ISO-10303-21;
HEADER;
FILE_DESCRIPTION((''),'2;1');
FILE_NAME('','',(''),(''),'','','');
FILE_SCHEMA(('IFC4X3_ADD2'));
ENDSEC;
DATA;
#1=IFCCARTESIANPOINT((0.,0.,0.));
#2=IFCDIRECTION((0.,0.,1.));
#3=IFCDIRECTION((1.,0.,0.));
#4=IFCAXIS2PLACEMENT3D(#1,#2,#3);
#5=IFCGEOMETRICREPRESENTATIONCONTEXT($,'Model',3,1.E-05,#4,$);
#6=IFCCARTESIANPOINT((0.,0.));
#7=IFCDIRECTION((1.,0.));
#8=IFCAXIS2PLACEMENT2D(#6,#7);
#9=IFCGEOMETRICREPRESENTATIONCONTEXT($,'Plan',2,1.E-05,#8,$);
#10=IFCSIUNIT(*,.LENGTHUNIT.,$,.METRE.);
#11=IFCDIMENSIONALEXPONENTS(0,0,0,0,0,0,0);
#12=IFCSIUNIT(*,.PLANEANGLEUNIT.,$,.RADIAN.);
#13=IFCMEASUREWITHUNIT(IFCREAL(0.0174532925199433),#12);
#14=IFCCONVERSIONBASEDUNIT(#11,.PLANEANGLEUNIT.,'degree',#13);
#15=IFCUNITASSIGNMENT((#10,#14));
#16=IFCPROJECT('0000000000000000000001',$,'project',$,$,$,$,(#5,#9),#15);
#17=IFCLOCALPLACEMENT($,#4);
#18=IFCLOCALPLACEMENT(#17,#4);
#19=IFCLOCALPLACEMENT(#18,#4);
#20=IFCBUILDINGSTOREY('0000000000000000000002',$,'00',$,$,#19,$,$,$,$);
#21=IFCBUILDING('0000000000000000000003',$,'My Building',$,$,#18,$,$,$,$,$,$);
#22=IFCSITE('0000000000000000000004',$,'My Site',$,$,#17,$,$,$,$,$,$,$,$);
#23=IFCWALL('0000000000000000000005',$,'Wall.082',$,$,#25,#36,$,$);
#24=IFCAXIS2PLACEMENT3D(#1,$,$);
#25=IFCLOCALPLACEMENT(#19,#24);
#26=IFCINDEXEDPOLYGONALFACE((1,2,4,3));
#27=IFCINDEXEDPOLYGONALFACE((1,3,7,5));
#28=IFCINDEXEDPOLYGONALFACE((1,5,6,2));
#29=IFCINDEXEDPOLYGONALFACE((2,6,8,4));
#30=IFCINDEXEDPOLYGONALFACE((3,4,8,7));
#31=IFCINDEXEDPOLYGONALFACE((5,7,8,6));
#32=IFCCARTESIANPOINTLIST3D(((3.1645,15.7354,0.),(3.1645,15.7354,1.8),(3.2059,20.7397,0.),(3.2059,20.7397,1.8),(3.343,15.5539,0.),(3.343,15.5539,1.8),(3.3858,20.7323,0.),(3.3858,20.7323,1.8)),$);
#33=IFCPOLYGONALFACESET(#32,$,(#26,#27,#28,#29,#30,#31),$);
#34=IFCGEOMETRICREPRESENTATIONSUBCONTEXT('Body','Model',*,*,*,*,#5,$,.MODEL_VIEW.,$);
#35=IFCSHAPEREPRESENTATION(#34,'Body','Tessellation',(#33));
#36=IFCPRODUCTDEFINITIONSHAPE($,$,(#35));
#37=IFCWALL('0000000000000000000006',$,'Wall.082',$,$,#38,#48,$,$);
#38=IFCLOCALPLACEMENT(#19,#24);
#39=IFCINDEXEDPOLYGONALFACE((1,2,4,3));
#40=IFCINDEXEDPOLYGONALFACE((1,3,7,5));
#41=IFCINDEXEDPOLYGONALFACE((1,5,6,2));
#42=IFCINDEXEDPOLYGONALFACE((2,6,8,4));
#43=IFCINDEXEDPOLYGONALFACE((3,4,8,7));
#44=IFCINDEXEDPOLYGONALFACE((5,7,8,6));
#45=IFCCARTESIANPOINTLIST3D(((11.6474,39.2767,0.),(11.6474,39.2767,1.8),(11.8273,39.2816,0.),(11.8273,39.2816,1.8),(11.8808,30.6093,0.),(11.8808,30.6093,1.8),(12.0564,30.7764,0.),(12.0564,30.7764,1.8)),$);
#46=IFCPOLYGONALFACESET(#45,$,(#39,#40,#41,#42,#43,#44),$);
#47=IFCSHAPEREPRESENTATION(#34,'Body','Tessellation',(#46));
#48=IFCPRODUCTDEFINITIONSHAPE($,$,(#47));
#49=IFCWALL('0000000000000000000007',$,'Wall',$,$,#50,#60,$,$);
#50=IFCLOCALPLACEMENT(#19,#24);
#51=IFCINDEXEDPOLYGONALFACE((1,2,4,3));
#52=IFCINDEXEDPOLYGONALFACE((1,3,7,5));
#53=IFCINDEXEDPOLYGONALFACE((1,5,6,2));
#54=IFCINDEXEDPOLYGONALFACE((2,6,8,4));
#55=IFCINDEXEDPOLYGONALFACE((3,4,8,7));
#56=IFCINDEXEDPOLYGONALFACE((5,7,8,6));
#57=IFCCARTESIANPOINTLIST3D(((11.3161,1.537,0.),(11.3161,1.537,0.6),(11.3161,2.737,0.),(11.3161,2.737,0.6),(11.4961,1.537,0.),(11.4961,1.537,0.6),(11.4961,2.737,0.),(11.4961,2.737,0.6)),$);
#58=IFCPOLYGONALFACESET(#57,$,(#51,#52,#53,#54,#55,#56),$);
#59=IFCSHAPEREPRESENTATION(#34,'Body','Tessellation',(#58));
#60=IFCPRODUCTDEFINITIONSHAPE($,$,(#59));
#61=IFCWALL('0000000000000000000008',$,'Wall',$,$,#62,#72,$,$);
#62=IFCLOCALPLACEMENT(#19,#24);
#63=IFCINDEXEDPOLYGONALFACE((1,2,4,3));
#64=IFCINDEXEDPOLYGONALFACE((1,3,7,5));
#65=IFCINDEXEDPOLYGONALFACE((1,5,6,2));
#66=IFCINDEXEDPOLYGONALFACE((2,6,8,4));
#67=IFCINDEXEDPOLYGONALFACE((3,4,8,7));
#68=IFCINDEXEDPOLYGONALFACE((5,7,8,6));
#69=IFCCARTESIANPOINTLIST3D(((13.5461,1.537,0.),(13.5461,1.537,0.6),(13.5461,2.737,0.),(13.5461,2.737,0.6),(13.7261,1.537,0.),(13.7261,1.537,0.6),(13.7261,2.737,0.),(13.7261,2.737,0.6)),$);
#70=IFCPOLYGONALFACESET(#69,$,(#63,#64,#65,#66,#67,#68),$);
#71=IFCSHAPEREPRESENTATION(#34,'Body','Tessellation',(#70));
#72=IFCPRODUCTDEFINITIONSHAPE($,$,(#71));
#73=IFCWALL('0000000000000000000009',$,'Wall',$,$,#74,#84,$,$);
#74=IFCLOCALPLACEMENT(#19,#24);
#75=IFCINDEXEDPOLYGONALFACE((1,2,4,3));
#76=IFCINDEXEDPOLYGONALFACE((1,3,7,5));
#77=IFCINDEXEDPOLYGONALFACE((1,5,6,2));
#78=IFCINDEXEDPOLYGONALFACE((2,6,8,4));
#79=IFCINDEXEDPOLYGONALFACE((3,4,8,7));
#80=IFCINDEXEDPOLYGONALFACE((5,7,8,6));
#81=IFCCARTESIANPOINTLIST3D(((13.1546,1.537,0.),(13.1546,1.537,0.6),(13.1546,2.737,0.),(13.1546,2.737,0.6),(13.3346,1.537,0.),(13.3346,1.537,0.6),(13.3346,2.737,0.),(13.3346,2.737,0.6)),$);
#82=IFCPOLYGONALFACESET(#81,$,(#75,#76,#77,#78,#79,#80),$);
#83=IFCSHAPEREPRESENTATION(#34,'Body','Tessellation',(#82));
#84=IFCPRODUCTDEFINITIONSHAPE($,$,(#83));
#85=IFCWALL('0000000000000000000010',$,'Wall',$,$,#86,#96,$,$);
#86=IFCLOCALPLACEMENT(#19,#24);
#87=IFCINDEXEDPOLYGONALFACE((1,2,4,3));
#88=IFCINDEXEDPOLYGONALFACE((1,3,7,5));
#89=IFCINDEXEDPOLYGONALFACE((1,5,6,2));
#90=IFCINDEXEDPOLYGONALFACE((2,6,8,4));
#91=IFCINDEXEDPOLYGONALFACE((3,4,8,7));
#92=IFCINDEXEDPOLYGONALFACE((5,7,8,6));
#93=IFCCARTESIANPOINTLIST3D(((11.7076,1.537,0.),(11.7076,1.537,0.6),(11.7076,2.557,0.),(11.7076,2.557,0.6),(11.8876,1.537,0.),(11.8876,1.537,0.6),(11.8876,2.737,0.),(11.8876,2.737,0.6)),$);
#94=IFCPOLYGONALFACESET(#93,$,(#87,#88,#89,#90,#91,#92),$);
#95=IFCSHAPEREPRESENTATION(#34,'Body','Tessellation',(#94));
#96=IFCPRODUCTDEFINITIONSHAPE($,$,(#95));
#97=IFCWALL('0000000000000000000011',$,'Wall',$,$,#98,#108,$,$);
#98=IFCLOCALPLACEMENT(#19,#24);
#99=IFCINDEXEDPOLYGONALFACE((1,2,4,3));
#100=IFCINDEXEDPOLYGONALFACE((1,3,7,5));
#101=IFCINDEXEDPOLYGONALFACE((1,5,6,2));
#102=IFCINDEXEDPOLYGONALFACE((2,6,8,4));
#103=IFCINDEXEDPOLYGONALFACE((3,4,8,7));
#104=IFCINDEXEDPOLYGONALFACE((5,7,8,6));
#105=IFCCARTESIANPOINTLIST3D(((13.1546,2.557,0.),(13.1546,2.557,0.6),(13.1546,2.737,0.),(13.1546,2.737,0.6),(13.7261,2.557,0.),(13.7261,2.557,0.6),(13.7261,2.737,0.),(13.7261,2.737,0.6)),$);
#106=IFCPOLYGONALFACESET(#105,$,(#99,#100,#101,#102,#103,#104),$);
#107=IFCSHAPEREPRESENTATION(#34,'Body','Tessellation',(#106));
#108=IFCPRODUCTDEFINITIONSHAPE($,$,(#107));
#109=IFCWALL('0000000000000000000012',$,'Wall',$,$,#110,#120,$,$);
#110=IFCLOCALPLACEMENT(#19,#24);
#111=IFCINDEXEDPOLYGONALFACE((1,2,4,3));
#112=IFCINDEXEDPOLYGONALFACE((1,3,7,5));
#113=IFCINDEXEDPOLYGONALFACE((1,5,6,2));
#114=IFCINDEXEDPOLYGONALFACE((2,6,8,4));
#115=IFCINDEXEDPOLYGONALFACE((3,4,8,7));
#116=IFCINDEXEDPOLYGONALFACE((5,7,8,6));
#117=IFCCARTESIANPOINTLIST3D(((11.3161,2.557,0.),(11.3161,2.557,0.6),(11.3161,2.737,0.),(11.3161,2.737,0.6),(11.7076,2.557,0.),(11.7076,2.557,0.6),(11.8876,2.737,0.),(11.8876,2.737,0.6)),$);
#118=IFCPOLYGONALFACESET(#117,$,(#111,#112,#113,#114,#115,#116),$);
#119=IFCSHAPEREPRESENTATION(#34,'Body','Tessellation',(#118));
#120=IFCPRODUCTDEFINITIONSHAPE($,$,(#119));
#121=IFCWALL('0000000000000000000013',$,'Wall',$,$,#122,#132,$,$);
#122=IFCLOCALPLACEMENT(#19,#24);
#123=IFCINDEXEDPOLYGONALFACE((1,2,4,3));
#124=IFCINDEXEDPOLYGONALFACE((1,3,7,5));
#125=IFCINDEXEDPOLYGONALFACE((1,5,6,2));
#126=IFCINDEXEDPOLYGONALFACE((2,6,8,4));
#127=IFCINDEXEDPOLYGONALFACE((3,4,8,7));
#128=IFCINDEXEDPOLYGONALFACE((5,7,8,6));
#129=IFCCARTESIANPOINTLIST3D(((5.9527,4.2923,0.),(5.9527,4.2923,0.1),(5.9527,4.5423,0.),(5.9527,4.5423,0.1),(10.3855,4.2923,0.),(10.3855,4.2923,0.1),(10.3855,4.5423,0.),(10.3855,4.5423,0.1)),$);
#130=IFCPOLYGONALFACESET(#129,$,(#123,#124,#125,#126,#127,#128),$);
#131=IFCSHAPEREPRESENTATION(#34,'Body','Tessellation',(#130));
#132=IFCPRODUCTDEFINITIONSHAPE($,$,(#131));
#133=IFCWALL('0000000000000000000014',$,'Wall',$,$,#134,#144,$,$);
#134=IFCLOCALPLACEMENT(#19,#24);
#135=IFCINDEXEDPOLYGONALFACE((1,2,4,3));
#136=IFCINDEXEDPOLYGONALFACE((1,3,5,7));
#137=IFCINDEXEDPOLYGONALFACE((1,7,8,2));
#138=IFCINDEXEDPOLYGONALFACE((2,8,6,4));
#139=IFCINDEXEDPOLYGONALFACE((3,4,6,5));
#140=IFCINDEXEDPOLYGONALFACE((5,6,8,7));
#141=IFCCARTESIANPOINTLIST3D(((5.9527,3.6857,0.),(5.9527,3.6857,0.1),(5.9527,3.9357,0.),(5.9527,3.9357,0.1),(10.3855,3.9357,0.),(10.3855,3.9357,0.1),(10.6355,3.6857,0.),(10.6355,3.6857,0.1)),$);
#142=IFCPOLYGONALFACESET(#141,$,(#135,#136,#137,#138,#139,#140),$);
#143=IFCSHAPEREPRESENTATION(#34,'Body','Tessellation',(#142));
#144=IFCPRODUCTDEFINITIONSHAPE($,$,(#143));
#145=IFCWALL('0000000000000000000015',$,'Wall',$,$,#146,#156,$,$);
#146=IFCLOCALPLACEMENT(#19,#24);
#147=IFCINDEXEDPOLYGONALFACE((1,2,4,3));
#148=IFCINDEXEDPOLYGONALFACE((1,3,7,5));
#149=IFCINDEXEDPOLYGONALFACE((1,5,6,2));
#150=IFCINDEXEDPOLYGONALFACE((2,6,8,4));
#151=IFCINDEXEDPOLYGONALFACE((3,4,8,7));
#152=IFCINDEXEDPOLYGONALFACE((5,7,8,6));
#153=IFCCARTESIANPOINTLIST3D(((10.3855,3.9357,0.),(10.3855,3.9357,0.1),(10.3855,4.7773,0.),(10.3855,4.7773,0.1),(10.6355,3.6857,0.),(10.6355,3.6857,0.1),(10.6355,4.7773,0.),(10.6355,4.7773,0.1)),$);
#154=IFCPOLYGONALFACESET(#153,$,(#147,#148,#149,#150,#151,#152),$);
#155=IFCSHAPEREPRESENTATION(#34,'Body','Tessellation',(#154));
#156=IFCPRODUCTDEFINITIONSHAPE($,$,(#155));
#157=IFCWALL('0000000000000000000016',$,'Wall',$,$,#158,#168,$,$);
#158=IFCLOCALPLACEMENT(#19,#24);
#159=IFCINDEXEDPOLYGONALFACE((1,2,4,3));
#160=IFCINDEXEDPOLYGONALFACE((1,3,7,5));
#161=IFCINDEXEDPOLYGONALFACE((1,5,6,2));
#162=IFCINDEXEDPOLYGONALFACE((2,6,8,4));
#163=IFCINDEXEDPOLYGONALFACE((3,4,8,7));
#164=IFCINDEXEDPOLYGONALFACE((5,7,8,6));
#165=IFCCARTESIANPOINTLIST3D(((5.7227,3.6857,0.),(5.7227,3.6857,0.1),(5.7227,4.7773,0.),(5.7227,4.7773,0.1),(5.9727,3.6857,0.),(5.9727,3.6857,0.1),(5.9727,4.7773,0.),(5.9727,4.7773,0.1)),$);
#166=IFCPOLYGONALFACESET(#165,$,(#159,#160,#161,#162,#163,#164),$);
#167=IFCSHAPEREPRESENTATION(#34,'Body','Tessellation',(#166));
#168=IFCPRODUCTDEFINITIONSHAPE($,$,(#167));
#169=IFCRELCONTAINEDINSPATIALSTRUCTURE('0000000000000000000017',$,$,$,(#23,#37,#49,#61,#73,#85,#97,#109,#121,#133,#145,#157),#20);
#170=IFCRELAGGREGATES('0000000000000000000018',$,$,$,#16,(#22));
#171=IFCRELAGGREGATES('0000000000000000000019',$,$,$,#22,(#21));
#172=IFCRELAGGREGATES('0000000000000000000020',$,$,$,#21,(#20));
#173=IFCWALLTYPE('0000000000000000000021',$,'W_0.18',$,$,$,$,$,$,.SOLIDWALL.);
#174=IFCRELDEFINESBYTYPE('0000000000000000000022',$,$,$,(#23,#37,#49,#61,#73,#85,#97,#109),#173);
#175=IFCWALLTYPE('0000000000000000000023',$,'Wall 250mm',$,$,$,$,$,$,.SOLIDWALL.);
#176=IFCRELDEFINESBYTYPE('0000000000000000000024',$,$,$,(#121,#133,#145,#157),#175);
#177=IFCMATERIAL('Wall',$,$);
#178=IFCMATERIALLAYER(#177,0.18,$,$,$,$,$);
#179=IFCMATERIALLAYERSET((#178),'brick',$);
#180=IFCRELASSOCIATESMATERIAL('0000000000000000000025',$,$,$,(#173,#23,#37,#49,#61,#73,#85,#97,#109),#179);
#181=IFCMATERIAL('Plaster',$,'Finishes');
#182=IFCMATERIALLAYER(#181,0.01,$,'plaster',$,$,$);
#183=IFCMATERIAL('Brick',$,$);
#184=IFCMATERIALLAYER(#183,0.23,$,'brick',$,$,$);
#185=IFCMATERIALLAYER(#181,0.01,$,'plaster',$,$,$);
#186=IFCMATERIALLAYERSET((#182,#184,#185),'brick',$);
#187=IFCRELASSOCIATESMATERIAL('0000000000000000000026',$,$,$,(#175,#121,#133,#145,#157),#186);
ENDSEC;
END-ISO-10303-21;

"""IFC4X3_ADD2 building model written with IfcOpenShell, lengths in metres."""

from ifc_helpers import new_model, entity, si_unit, converted_unit, frame, origin_with_axes, origin_2d_with_axis, place, context, subcontext, project, spatial, line, indexed_curve, outline, extrude, material, layer, layer_set, layer_usage, type_object, element, save


model = new_model("IFC4X3_ADD2")

# Units and contexts
model_context = context("Model", 3, precision=1e-05, world=origin_with_axes())
plan_context = context("Plan", 2, precision=1e-05, world=origin_2d_with_axis())
body_context_1 = subcontext(model_context, "Body", "Model", "MODEL_VIEW")
ifc_project = project(units=[si_unit("LENGTHUNIT", "METRE"), converted_unit("PLANEANGLEUNIT", "degree", entity("IfcReal", 0.0174532925199433), si_unit("PLANEANGLEUNIT", "RADIAN"), dimensions=[0, 0, 0, 0, 0, 0, 0])], contexts=[model_context, plan_context])

# Site, building, storey
site_placement = place(None, origin_with_axes())
site = spatial("IfcSite", under=ifc_project, at=site_placement, Name="My Site")
building_placement = place(site_placement, origin_with_axes())
building = spatial("IfcBuilding", under=site, at=building_placement, Name="My Building")
storey_placement = place(building_placement, origin_with_axes())
storey = spatial("IfcBuildingStorey", under=building, at=storey_placement, Name="00")

# Shared definitions
ifc_material_1 = material(Name="Wall")
ifc_layer_1 = layer(ifc_material_1, 0.18)
ifc_layer_set_1 = layer_set([ifc_layer_1], Name="brick")
wall_type_1 = type_object("IfcWallType", Name="W_0.18", PredefinedType="SOLIDWALL", material=ifc_layer_set_1)

# Walls
ifc_layer_usage_1 = layer_usage(ifc_layer_set_1, "AXIS2", "POSITIVE", 0.0)
wall_1_placement = place(storey_placement, frame((3.2059, 20.7397, 0.0), z_axis=(0.0, 0.0, 1.0), x_axis=(-0.008279, -0.999966, 0.0)))
element("IfcWall", 1, at=wall_1_placement, inside=storey, type_object=wall_type_1, material=ifc_layer_usage_1, Name="Wall.082", context=body_context_1, shape_type="SweptSolid", body=[
    extrude(outline(indexed_curve([(0.0, 0.0), (0.0059, 0.18), (5.1845, 0.18), (5.0045, 0.0)], segments=[line(1, 2, 3, 4, 1)])), origin_with_axes(), (0.0, 0.0, 1.0), 1.8),
])
ifc_layer_usage_2 = layer_usage(ifc_layer_set_1, "AXIS2", "NEGATIVE", 0.0)
wall_2_placement = place(storey_placement, frame((11.8273, 39.2816, 0.0), z_axis=(0.0, 0.0, 1.0), x_axis=(0.026917, -0.999638, 0.0)))
element("IfcWall", 2, at=wall_2_placement, inside=storey, type_object=wall_type_1, material=ifc_layer_usage_2, Name="Wall.082", context=body_context_1, shape_type="SweptSolid", body=[
    extrude(outline(indexed_curve([(0.0, -0.18), (0.0, 0.0), (8.5083, 0.0), (8.6705, -0.18)], segments=[line(1, 2, 3, 4, 1)])), origin_with_axes(), (0.0, 0.0, 1.0), 1.8),
])
ifc_layer_usage_3 = layer_usage(ifc_layer_set_1, "AXIS2", "POSITIVE", 0.0)
wall_3_placement = place(storey_placement, frame((11.4961, 1.537, 0.0), z_axis=(0.0, 0.0, 1.0), x_axis=(0.000001, 1.0, 0.0)))
element("IfcWall", 3, at=wall_3_placement, inside=storey, type_object=wall_type_1, material=ifc_layer_usage_3, Name="Wall", context=body_context_1, shape_type="SweptSolid", body=[
    extrude(outline(indexed_curve([(0.0, 0.0), (0.0, 0.18), (1.2, 0.18), (1.2, 0.0)], segments=[line(1, 2, 3, 4, 1)])), origin_with_axes(), (0.0, 0.0, 1.0), 0.6),
])
ifc_layer_usage_4 = layer_usage(ifc_layer_set_1, "AXIS2", "POSITIVE", 0.0)
wall_4_placement = place(storey_placement, frame((13.7261, 1.537, 0.0), z_axis=(0.0, 0.0, 1.0), x_axis=(0.000001, 1.0, 0.0)))
element("IfcWall", 4, at=wall_4_placement, inside=storey, type_object=wall_type_1, material=ifc_layer_usage_4, Name="Wall", context=body_context_1, shape_type="SweptSolid", body=[
    extrude(outline(indexed_curve([(0.0, 0.0), (0.0, 0.18), (1.2, 0.18), (1.2, 0.0)], segments=[line(1, 2, 3, 4, 1)])), origin_with_axes(), (0.0, 0.0, 1.0), 0.6),
])
ifc_layer_usage_5 = layer_usage(ifc_layer_set_1, "AXIS2", "POSITIVE", 0.0)
wall_5_placement = place(storey_placement, frame((13.3346, 1.537, 0.0), z_axis=(0.0, 0.0, 1.0), x_axis=(0.000001, 1.0, 0.0)))
element("IfcWall", 5, at=wall_5_placement, inside=storey, type_object=wall_type_1, material=ifc_layer_usage_5, Name="Wall", context=body_context_1, shape_type="SweptSolid", body=[
    extrude(outline(indexed_curve([(0.0, 0.0), (0.0, 0.18), (1.2, 0.18), (1.2, 0.0)], segments=[line(1, 2, 3, 4, 1)])), origin_with_axes(), (0.0, 0.0, 1.0), 0.6),
])
ifc_layer_usage_6 = layer_usage(ifc_layer_set_1, "AXIS2", "POSITIVE", 0.0)
wall_6_placement = place(storey_placement, frame((11.8876, 1.537, 0.0), z_axis=(0.0, 0.0, 1.0), x_axis=(0.000001, 1.0, 0.0)))
element("IfcWall", 6, at=wall_6_placement, inside=storey, type_object=wall_type_1, material=ifc_layer_usage_6, Name="Wall", context=body_context_1, shape_type="SweptSolid", body=[
    extrude(outline(indexed_curve([(0.0, 0.0), (0.0, 0.18), (1.02, 0.18), (1.2, 0.0)], segments=[line(1, 2, 3, 4, 1)])), origin_with_axes(), (0.0, 0.0, 1.0), 0.6),
])
ifc_layer_usage_7 = layer_usage(ifc_layer_set_1, "AXIS2", "POSITIVE", 0.0)
wall_7_placement = place(storey_placement, frame((13.7261, 2.737, 0.0), z_axis=(0.0, 0.0, 1.0), x_axis=(-1.0, 0.000001, 0.0)))
element("IfcWall", 7, at=wall_7_placement, inside=storey, type_object=wall_type_1, material=ifc_layer_usage_7, Name="Wall", context=body_context_1, shape_type="SweptSolid", body=[
    extrude(outline(indexed_curve([(0.0, 0.0), (0.0, 0.18), (0.5715, 0.18), (0.5715, 0.0)], segments=[line(1, 2, 3, 4, 1)])), origin_with_axes(), (0.0, 0.0, 1.0), 0.6),
])
ifc_layer_usage_8 = layer_usage(ifc_layer_set_1, "AXIS2", "POSITIVE", 0.0)
wall_8_placement = place(storey_placement, frame((11.8876, 2.737, 0.0), z_axis=(0.0, 0.0, 1.0), x_axis=(-1.0, 0.000001, 0.0)))
element("IfcWall", 8, at=wall_8_placement, inside=storey, type_object=wall_type_1, material=ifc_layer_usage_8, Name="Wall", context=body_context_1, shape_type="SweptSolid", body=[
    extrude(outline(indexed_curve([(0.0, 0.0), (0.18, 0.18), (0.5715, 0.18), (0.5715, 0.0)], segments=[line(1, 2, 3, 4, 1)])), origin_with_axes(), (0.0, 0.0, 1.0), 0.6),
])
ifc_material_2 = material(Name="Plaster", Category="Finishes")
ifc_layer_2 = layer(ifc_material_2, 0.01, Name="plaster")
ifc_material_3 = material(Name="Brick")
ifc_layer_3 = layer(ifc_material_3, 0.23, Name="brick")
ifc_layer_4 = layer(ifc_material_2, 0.01, Name="plaster")
ifc_layer_set_2 = layer_set([ifc_layer_2, ifc_layer_3, ifc_layer_4], Name="brick")
ifc_layer_usage_9 = layer_usage(ifc_layer_set_2, "AXIS2", "POSITIVE", 0.0)
wall_type_2 = type_object("IfcWallType", Name="Wall 250mm", PredefinedType="SOLIDWALL", material=ifc_layer_set_2)
wall_9_placement = place(storey_placement, frame((5.9527, 4.2923, 0.0), z_axis=(0.0, 0.0, 1.0), x_axis=(1.0, 0.0, 0.0)))
element("IfcWall", 9, at=wall_9_placement, inside=storey, type_object=wall_type_2, material=ifc_layer_usage_9, Name="Wall", context=body_context_1, shape_type="SweptSolid", body=[
    extrude(outline(indexed_curve([(0.0, 0.0), (0.0, 0.25), (4.4327, 0.25), (4.4327, 0.0)], segments=[line(1, 2, 3, 4, 1)])), origin_with_axes(), (0.0, 0.0, 1.0), 0.1),
])
ifc_layer_usage_10 = layer_usage(ifc_layer_set_2, "AXIS2", "POSITIVE", 0.0)
wall_10_placement = place(storey_placement, frame((5.9527, 3.6857, 0.0), z_axis=(0.0, 0.0, 1.0), x_axis=(1.0, 0.0, 0.0)))
element("IfcWall", 10, at=wall_10_placement, inside=storey, type_object=wall_type_2, material=ifc_layer_usage_10, Name="Wall", context=body_context_1, shape_type="SweptSolid", body=[
    extrude(outline(indexed_curve([(0.0, 0.0), (0.0, 0.25), (4.4327, 0.25), (4.6827, 0.0)], segments=[line(1, 2, 3, 4, 1)])), origin_with_axes(), (0.0, 0.0, 1.0), 0.1),
])
ifc_layer_usage_11 = layer_usage(ifc_layer_set_2, "AXIS2", "POSITIVE", 0.0)
wall_11_placement = place(storey_placement, frame((10.3855, 4.7773, 0.0), z_axis=(0.0, 0.0, 1.0), x_axis=(-0.000001, -1.0, 0.0)))
element("IfcWall", 11, at=wall_11_placement, inside=storey, type_object=wall_type_2, material=ifc_layer_usage_11, Name="Wall", context=body_context_1, shape_type="SweptSolid", body=[
    extrude(outline(indexed_curve([(0.0, 0.0), (0.0, 0.25), (1.0916, 0.25), (0.8416, 0.0)], segments=[line(1, 2, 3, 4, 1)])), origin_with_axes(), (0.0, 0.0, 1.0), 0.1),
])
ifc_layer_usage_12 = layer_usage(ifc_layer_set_2, "AXIS2", "POSITIVE", 0.0)
wall_12_placement = place(storey_placement, frame((5.7227, 4.7773, 0.0), z_axis=(0.0, 0.0, 1.0), x_axis=(-0.000001, -1.0, 0.0)))
element("IfcWall", 12, at=wall_12_placement, inside=storey, type_object=wall_type_2, material=ifc_layer_usage_12, Name="Wall", context=body_context_1, shape_type="SweptSolid", body=[
    extrude(outline(indexed_curve([(0.0, 0.0), (0.0, 0.25), (1.0916, 0.25), (1.0916, 0.0)], segments=[line(1, 2, 3, 4, 1)])), origin_with_axes(), (0.0, 0.0, 1.0), 0.1),
])

save(model, "model.ifc")
